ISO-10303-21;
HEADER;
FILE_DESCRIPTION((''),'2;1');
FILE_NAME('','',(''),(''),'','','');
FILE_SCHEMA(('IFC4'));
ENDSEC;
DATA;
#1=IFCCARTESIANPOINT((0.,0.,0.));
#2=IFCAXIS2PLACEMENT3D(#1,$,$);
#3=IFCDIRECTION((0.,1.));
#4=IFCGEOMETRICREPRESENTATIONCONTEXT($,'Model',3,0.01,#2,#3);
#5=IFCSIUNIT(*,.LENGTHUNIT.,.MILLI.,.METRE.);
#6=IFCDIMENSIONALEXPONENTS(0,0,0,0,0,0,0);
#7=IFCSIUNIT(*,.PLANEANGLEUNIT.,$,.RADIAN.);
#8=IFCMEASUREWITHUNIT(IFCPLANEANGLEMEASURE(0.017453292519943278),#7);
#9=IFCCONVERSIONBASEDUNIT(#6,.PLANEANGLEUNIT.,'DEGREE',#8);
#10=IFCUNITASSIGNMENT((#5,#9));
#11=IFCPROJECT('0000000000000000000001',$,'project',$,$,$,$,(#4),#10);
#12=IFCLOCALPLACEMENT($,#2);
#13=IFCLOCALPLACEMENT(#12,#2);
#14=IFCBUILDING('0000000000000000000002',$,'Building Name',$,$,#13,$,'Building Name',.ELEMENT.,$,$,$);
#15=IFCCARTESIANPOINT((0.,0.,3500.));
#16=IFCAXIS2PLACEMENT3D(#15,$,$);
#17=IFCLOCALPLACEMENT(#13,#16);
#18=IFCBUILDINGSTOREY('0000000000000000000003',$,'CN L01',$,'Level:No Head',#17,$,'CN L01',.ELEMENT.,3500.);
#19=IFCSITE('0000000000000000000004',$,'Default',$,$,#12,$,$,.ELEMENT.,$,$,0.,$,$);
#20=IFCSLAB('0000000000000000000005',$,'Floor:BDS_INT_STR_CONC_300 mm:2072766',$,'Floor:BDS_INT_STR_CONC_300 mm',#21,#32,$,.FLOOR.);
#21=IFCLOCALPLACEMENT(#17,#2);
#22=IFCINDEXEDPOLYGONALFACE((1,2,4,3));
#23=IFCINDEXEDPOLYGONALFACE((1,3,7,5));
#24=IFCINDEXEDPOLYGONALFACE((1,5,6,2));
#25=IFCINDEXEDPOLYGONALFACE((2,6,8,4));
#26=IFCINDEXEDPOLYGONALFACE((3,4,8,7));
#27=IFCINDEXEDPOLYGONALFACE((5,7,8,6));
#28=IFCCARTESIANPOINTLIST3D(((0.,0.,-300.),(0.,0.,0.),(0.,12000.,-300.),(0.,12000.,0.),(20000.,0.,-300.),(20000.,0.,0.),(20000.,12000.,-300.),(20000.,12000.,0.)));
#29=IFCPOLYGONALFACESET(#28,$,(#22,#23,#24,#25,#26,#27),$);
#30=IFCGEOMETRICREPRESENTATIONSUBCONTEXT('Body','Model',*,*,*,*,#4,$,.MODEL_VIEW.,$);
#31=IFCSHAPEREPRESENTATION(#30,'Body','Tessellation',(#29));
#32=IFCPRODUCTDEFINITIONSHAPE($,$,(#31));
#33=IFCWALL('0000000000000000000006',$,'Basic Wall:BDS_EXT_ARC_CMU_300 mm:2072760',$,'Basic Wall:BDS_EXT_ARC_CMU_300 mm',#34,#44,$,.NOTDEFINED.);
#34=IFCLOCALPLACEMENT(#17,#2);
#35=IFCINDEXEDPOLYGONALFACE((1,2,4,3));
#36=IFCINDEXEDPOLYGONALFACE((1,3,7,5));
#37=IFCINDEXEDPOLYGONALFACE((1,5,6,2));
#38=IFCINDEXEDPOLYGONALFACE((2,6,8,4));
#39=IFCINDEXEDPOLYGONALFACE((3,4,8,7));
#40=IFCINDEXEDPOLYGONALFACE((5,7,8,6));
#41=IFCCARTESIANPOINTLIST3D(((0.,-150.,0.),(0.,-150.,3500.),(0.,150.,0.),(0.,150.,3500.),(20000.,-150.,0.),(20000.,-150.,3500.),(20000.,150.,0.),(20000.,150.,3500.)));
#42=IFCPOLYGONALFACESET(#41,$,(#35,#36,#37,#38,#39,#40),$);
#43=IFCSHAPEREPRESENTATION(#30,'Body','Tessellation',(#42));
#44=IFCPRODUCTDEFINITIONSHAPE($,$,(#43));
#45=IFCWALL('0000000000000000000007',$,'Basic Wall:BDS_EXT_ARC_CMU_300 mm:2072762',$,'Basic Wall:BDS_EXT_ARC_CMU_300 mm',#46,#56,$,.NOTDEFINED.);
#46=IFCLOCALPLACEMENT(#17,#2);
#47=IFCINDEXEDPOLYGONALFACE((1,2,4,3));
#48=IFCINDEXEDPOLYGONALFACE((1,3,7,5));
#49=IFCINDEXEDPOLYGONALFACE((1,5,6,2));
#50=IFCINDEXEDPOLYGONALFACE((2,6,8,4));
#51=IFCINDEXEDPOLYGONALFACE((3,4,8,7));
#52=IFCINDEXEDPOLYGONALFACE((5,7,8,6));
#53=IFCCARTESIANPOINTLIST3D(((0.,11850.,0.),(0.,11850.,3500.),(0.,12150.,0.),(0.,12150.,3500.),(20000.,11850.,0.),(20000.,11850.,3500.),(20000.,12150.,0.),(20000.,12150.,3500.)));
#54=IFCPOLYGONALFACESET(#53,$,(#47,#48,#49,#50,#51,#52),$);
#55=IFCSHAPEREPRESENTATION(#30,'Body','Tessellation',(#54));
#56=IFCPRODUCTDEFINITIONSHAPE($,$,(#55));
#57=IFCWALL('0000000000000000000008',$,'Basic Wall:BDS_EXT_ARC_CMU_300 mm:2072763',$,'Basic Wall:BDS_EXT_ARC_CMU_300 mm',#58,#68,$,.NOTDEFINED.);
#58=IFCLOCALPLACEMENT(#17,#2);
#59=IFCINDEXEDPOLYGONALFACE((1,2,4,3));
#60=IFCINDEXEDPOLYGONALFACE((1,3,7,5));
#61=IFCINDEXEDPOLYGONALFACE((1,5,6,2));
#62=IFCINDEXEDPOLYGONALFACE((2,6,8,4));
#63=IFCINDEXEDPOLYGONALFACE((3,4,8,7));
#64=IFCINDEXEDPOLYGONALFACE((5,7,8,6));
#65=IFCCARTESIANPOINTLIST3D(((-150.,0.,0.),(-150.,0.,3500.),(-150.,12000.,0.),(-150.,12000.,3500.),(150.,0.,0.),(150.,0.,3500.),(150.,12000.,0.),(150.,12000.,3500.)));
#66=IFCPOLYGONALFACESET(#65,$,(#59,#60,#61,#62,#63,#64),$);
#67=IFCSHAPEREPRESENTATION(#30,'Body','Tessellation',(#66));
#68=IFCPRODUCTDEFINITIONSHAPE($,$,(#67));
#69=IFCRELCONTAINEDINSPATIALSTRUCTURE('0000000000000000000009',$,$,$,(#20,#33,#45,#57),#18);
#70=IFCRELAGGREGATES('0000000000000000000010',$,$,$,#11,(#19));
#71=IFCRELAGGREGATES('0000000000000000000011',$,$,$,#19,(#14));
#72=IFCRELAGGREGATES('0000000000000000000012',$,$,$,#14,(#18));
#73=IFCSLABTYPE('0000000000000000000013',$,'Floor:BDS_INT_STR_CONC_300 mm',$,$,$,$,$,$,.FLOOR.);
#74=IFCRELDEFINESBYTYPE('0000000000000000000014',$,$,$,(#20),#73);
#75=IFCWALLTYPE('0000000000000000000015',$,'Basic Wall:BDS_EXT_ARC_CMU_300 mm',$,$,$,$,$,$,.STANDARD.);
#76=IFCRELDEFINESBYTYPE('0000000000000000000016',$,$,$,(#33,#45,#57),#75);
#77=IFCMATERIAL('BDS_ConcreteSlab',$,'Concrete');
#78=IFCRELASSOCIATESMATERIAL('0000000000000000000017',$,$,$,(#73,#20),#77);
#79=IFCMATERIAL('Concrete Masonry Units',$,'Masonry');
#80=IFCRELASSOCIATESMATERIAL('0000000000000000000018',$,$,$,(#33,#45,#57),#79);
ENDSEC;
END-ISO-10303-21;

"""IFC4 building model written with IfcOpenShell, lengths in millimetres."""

from ifc_helpers import new_model, entity, si_unit, converted_unit, direction, frame, origin, place, context, subcontext, project, spatial, indexed_curve, outline, extrude, material, type_object, element, save


model = new_model("IFC4")

# Units and contexts
model_context = context("Model", 3, precision=0.01, world=origin(), true_north=direction((0.0, 1.0)))
body_context = subcontext(model_context, "Body", "Model", "MODEL_VIEW")
ifc_project = project(units=[si_unit("LENGTHUNIT", "METRE", prefix="MILLI"), converted_unit("PLANEANGLEUNIT", "DEGREE", entity("IfcPlaneAngleMeasure", 0.017453292519943278), si_unit("PLANEANGLEUNIT", "RADIAN"), dimensions=[0, 0, 0, 0, 0, 0, 0])], contexts=[model_context])

# Site, building, storey
site_placement = place(None, origin())
site = spatial("IfcSite", under=ifc_project, at=site_placement, Name="Default", CompositionType="ELEMENT", RefElevation=0.0)
building_placement = place(site_placement, origin())
building = spatial("IfcBuilding", under=site, at=building_placement, Name="Building Name", LongName="Building Name", CompositionType="ELEMENT")
storey_placement = place(building_placement, frame((0.0, 0.0, 3500.0)))
storey = spatial("IfcBuildingStorey", under=building, at=storey_placement, Name="CN L01", ObjectType="Level:No Head", LongName="CN L01", CompositionType="ELEMENT", Elevation=3500.0)

# Slab
ifc_material_1 = material(Name="BDS_ConcreteSlab", Category="Concrete")
slab_type = type_object("IfcSlabType", Name="Floor:BDS_INT_STR_CONC_300 mm", PredefinedType="FLOOR", material=ifc_material_1)
slab_placement = place(storey_placement, origin())
element("IfcSlab", 1, at=slab_placement, inside=storey, type_object=slab_type, material=ifc_material_1, Name="Floor:BDS_INT_STR_CONC_300 mm:2072766", ObjectType="Floor:BDS_INT_STR_CONC_300 mm", PredefinedType="FLOOR", context=body_context, shape_type="SweptSolid", body=[
    extrude(outline(indexed_curve([(-6000.0, -10000.0), (6000.0, -10000.0), (6000.0, 10000.0), (-6000.0, 10000.0), (-6000.0, -10000.0)], self_intersect=False)), frame((10000.0, 6000.0, 0.0), z_axis=(0.0, 0.0, -1.0), x_axis=(0.0, 1.0, 0.0)), (0.0, 0.0, 1.0), 300.0),
])

# Walls
ifc_material_2 = material(Name="Concrete Masonry Units", Category="Masonry")
wall_type = type_object("IfcWallType", Name="Basic Wall:BDS_EXT_ARC_CMU_300 mm", PredefinedType="STANDARD")
wall_1_placement = place(storey_placement, origin())
element("IfcWall", 2, at=wall_1_placement, inside=storey, type_object=wall_type, material=ifc_material_2, Name="Basic Wall:BDS_EXT_ARC_CMU_300 mm:2072760", ObjectType="Basic Wall:BDS_EXT_ARC_CMU_300 mm", PredefinedType="NOTDEFINED", context=body_context, shape_type="SweptSolid", body=[
    extrude(outline(indexed_curve([(20000.0, 150.0), (0.0, 150.0), (0.0, -150.0), (20000.0, -150.0), (20000.0, 150.0)], self_intersect=False)), origin(), (0.0, 0.0, 1.0), 3500.0),
])
wall_2_placement = place(storey_placement, frame((20000.0, 12000.0, 0.0), z_axis=(0.0, 0.0, 1.0), x_axis=(-1.0, 0.0, 0.0)))
element("IfcWall", 3, at=wall_2_placement, inside=storey, type_object=wall_type, material=ifc_material_2, Name="Basic Wall:BDS_EXT_ARC_CMU_300 mm:2072762", ObjectType="Basic Wall:BDS_EXT_ARC_CMU_300 mm", PredefinedType="NOTDEFINED", context=body_context, shape_type="SweptSolid", body=[
    extrude(outline(indexed_curve([(20000.0, 150.0), (0.0, 150.0), (0.0, -150.0), (20000.0, -150.0), (20000.0, 150.0)], self_intersect=False)), origin(), (0.0, 0.0, 1.0), 3500.0),
])
wall_3_placement = place(storey_placement, frame((0.0, 12000.0, 0.0), z_axis=(0.0, 0.0, 1.0), x_axis=(0.0, -1.0, 0.0)))
element("IfcWall", 4, at=wall_3_placement, inside=storey, type_object=wall_type, material=ifc_material_2, Name="Basic Wall:BDS_EXT_ARC_CMU_300 mm:2072763", ObjectType="Basic Wall:BDS_EXT_ARC_CMU_300 mm", PredefinedType="NOTDEFINED", context=body_context, shape_type="SweptSolid", body=[
    extrude(outline(indexed_curve([(12000.0, 150.0), (0.0, 150.0), (0.0, -150.0), (12000.0, -150.0), (12000.0, 150.0)], self_intersect=False)), origin(), (0.0, 0.0, 1.0), 3500.0),
])

save(model, "model.ifc")
